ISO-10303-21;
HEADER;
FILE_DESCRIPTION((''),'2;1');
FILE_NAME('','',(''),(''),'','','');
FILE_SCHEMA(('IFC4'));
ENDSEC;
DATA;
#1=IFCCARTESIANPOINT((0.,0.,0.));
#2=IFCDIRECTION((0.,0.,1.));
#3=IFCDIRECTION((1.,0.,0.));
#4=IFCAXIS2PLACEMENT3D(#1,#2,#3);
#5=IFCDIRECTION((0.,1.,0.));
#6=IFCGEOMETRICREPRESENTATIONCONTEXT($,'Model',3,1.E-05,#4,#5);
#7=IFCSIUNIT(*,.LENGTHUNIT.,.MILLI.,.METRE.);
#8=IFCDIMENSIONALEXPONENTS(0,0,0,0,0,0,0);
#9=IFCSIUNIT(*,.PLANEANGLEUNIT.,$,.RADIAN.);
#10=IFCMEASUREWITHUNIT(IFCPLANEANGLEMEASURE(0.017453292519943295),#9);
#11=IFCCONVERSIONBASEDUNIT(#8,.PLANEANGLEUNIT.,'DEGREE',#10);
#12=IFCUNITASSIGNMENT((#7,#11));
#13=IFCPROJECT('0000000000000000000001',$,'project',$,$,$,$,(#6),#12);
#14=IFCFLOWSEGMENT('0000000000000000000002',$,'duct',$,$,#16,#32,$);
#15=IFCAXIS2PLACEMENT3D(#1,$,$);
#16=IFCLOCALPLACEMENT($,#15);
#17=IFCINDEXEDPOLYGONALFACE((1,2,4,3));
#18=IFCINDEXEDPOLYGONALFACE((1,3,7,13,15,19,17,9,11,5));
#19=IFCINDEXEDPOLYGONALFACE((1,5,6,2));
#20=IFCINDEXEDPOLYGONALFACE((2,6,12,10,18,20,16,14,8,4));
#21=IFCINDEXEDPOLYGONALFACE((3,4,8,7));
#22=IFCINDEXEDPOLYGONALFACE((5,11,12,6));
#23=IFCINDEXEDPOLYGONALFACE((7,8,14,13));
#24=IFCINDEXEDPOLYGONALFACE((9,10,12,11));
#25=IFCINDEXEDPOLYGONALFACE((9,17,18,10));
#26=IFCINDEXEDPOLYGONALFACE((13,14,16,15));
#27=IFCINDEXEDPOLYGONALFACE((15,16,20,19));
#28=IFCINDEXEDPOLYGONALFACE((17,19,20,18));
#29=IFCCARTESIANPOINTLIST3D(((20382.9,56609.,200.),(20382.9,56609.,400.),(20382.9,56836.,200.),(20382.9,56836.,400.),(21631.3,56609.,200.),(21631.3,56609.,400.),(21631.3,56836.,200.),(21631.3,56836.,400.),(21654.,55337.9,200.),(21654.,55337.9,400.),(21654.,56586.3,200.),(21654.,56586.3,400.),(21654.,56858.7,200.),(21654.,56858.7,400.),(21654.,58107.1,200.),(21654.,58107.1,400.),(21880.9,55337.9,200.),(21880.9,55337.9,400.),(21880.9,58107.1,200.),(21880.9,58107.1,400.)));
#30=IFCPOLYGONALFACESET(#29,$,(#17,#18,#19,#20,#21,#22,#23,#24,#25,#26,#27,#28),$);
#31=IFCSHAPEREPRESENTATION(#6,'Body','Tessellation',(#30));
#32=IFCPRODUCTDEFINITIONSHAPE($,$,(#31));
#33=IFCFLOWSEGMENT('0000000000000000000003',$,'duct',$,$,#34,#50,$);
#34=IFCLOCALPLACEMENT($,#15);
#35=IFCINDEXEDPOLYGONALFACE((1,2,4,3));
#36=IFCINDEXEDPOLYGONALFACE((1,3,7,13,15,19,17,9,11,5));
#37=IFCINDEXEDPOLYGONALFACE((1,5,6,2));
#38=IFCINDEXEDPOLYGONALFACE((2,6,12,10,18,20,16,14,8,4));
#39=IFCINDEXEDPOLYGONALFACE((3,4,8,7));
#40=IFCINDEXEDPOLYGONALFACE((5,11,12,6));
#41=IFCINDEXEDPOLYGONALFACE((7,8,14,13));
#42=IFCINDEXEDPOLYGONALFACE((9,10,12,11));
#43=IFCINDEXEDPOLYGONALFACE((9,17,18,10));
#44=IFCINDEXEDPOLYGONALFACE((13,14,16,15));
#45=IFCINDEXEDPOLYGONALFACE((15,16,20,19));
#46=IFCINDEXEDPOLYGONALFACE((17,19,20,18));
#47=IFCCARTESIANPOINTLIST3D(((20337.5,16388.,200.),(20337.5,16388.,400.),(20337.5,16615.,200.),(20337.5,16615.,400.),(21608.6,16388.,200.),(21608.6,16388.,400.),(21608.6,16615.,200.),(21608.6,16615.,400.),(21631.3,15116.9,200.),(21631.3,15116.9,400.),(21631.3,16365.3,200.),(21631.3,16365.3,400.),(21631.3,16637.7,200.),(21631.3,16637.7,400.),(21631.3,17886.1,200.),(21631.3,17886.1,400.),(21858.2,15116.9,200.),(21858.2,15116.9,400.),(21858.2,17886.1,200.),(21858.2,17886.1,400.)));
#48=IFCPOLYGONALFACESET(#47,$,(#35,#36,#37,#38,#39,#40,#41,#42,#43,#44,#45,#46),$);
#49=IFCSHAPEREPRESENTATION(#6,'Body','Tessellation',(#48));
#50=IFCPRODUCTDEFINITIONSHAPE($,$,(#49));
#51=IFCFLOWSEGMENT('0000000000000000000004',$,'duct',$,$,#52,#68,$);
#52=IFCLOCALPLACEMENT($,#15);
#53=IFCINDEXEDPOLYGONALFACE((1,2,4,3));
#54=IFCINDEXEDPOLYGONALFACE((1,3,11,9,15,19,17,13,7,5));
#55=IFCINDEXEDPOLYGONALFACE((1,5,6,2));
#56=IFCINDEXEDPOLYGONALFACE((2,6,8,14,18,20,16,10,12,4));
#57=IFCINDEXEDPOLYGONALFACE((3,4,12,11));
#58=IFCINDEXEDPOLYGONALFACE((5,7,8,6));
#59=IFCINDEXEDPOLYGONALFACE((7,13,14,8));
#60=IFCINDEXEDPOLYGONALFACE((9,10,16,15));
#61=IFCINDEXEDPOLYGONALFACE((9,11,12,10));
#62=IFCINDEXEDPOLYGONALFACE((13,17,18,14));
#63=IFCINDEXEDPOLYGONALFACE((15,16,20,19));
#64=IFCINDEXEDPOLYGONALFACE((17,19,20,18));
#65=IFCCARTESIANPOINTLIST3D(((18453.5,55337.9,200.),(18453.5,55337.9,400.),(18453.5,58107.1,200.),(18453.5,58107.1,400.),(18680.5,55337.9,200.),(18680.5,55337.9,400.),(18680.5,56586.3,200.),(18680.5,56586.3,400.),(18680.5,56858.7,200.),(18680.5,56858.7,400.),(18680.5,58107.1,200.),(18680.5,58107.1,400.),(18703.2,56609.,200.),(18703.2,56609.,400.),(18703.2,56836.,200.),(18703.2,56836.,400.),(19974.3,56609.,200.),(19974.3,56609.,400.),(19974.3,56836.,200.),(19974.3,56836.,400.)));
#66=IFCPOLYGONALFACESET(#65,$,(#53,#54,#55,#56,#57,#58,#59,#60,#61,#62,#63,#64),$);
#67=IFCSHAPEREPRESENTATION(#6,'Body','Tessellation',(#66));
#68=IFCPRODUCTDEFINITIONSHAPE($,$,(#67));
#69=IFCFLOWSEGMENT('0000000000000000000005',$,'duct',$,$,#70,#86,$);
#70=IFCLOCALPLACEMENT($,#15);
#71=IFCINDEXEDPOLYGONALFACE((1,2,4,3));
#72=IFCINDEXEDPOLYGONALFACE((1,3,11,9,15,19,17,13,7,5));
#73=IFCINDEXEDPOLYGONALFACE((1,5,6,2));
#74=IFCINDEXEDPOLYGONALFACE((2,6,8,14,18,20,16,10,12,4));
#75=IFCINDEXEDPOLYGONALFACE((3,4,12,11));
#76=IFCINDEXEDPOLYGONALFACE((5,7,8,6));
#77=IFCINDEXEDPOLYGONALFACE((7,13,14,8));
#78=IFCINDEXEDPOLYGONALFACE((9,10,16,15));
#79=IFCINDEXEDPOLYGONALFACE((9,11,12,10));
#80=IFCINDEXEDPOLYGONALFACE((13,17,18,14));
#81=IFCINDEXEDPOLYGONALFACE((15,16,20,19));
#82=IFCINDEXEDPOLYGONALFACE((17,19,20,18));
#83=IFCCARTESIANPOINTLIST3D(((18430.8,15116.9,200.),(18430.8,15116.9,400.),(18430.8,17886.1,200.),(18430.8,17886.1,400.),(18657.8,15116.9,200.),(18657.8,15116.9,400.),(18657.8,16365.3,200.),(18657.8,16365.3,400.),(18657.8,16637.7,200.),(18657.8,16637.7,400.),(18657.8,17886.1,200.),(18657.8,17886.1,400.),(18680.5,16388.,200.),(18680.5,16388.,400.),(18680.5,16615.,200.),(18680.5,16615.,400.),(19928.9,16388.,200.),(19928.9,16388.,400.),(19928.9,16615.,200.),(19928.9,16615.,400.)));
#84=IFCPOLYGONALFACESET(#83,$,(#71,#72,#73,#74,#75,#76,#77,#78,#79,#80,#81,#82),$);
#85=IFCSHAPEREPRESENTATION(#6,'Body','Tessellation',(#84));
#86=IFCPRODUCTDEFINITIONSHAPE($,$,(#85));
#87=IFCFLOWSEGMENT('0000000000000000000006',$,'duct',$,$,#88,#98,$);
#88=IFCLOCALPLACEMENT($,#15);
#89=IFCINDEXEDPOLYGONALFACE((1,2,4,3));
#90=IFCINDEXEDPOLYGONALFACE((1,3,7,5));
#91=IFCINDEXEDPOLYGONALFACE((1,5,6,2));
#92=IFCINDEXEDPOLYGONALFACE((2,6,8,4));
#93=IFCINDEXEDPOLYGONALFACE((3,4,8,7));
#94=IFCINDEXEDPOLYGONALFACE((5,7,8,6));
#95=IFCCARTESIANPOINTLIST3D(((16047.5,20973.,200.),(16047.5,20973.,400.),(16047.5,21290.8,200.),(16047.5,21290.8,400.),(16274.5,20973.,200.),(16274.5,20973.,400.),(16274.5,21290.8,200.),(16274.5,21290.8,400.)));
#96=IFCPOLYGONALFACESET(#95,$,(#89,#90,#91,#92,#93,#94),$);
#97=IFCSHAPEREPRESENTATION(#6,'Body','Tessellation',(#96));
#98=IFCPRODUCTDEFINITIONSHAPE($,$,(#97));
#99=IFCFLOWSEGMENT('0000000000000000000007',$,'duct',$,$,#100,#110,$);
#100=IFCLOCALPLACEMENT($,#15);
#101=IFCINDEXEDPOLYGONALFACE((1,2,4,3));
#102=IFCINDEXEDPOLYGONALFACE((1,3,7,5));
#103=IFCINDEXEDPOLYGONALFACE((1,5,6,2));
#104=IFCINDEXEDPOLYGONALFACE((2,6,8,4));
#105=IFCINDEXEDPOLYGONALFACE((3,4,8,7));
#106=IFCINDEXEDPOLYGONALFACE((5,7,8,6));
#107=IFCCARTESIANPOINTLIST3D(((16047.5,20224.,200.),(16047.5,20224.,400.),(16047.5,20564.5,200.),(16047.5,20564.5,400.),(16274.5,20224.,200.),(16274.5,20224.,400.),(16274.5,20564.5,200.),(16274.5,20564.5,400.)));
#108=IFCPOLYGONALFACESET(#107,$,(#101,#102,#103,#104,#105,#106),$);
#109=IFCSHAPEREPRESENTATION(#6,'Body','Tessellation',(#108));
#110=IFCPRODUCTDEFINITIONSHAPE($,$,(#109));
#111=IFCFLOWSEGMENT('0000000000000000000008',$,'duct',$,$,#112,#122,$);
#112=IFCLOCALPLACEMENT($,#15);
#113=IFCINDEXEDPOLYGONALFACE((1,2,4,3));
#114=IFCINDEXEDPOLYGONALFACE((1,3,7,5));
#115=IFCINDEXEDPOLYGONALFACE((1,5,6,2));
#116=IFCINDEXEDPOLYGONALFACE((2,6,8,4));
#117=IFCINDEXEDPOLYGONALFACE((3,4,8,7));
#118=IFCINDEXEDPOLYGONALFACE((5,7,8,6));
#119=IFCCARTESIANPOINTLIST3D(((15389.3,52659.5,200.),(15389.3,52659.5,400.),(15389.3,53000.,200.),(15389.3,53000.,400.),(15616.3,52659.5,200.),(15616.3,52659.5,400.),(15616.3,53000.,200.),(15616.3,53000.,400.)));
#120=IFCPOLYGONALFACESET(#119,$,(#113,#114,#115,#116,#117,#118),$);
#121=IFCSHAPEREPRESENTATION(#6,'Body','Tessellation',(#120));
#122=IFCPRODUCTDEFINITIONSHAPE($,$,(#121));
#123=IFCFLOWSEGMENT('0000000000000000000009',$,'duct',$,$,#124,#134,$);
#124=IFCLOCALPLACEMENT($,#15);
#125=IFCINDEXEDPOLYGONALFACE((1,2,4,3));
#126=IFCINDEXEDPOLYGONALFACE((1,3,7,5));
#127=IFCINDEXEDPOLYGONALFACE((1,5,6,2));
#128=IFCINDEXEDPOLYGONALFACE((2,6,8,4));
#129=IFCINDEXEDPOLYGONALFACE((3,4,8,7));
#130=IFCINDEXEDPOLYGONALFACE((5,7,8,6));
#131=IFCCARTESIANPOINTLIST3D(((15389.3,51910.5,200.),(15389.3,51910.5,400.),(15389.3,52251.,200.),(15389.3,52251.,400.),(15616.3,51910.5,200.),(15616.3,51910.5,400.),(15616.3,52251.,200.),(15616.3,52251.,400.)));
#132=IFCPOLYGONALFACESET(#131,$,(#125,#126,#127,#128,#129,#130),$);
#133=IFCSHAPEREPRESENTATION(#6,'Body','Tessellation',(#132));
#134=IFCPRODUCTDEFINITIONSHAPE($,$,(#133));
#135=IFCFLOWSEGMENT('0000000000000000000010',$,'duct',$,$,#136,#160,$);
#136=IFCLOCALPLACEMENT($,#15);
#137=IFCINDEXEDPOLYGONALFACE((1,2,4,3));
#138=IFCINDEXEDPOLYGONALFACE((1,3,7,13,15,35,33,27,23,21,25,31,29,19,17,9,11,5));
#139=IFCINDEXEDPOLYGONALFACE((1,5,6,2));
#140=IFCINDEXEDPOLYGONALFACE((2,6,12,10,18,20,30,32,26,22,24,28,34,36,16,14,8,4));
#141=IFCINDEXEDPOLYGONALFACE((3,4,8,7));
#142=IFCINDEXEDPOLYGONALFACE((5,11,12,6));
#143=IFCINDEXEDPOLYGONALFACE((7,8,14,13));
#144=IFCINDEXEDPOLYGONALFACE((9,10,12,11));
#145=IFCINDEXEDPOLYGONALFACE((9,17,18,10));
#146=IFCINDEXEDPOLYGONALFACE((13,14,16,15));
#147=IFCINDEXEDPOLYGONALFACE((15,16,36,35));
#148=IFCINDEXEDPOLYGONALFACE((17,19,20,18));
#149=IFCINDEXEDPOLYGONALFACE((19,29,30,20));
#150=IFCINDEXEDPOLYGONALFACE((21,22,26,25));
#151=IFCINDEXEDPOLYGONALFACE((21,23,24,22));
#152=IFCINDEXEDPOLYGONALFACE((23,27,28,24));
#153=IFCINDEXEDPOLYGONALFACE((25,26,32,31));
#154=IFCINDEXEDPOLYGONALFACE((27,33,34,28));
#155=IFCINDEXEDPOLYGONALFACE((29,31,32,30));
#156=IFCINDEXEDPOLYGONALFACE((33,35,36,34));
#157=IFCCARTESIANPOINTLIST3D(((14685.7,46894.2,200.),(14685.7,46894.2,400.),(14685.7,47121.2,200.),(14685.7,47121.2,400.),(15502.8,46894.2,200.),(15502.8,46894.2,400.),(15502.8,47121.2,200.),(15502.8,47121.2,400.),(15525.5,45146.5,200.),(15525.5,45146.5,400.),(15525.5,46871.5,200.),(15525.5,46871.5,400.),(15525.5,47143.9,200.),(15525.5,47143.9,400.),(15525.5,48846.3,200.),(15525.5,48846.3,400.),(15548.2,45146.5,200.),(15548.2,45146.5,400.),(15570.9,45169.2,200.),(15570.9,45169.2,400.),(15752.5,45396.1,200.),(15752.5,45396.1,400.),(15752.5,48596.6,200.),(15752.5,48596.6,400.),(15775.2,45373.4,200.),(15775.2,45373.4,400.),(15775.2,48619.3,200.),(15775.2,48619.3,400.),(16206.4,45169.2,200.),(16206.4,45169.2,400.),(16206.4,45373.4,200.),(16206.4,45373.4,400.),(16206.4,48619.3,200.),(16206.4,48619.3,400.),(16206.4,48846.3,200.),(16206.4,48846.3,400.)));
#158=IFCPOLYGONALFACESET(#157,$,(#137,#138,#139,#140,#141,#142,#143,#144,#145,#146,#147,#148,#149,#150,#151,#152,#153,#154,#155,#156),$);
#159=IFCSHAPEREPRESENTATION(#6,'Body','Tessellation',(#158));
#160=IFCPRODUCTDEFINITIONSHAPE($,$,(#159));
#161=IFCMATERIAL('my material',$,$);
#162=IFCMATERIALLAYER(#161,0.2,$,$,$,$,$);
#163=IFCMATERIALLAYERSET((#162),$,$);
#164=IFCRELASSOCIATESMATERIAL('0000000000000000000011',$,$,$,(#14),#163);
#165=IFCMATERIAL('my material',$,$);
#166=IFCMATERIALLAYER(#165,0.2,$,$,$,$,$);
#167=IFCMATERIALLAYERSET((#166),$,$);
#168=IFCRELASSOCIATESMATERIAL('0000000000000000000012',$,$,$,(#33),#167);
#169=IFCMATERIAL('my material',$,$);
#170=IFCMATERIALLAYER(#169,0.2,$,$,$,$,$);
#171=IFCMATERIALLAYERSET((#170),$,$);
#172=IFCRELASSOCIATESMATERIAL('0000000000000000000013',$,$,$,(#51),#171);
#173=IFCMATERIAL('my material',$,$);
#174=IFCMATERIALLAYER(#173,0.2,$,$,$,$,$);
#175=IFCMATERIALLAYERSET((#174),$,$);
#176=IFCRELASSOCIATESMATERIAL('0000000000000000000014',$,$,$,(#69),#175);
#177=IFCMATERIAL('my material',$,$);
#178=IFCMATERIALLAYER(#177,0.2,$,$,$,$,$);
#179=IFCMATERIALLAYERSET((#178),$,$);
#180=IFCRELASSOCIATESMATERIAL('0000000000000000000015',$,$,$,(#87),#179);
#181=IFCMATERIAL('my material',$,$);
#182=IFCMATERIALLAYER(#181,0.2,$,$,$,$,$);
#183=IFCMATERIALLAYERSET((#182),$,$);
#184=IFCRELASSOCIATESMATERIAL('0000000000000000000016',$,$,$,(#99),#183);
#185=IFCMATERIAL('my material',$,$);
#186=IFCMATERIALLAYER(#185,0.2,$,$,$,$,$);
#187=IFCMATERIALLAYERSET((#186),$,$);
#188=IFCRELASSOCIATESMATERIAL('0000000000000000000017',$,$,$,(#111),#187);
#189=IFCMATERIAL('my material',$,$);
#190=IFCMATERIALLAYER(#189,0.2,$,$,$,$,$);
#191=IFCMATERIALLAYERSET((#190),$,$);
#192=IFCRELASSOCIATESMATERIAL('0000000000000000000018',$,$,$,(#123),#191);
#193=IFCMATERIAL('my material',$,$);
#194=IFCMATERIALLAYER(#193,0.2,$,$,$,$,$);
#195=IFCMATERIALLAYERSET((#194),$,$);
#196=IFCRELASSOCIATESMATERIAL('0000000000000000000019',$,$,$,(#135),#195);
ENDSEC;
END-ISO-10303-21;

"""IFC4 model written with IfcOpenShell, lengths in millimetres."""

from ifc_helpers import new_model, entity, si_unit, converted_unit, direction, frame, origin_with_axes, place, context, project, polyline, outline, extrude, material, layer, layer_set, layer_usage, element, save


model = new_model("IFC4")

# Units and contexts
model_context = context("Model", 3, precision=1e-05, world=origin_with_axes(), true_north=direction((0.0, 1.0, 0.0)))
ifc_project = project(units=[si_unit("LENGTHUNIT", "METRE", prefix="MILLI"), converted_unit("PLANEANGLEUNIT", "DEGREE", entity("IfcPlaneAngleMeasure", 0.017453292519943295), si_unit("PLANEANGLEUNIT", "RADIAN"), dimensions=[0, 0, 0, 0, 0, 0, 0])], contexts=[model_context])

# Flow segments
ifc_material_1 = material(Name="my material")
ifc_layer_1 = layer(ifc_material_1, 0.2)
ifc_layer_set_1 = layer_set([ifc_layer_1])
ifc_layer_usage_1 = layer_usage(ifc_layer_set_1, "AXIS2", "POSITIVE", -0.1)
flow_segment_1_placement = place(None, origin_with_axes())
element("IfcFlowSegment", 1, at=flow_segment_1_placement, material=ifc_layer_usage_1, Name="duct", context=model_context, shape_type="SweptSolid", body=[
    extrude(outline(polyline([(20382.9, 56609.0), (21631.3, 56609.0), (21654.0, 56586.3), (21654.0, 55337.9), (21880.9, 55337.9), (21880.9, 58107.1), (21654.0, 58107.1), (21654.0, 56858.7), (21631.3, 56836.0), (20382.9, 56836.0), (20382.9, 56609.0)])), frame((0.0, 0.0, 200.0), z_axis=(0.0, 0.0, 1.0), x_axis=(1.0, 0.0, 0.0)), (0.0, 0.0, 1.0), 200.0),
])
ifc_material_2 = material(Name="my material")
ifc_layer_2 = layer(ifc_material_2, 0.2)
ifc_layer_set_2 = layer_set([ifc_layer_2])
ifc_layer_usage_2 = layer_usage(ifc_layer_set_2, "AXIS2", "POSITIVE", -0.1)
flow_segment_2_placement = place(None, origin_with_axes())
element("IfcFlowSegment", 2, at=flow_segment_2_placement, material=ifc_layer_usage_2, Name="duct", context=model_context, shape_type="SweptSolid", body=[
    extrude(outline(polyline([(20337.5, 16388.0), (21608.6, 16388.0), (21631.3, 16365.3), (21631.3, 15116.9), (21858.2, 15116.9), (21858.2, 17886.1), (21631.3, 17886.1), (21631.3, 16637.7), (21608.6, 16615.0), (20337.5, 16615.0), (20337.5, 16388.0)])), frame((0.0, 0.0, 200.0), z_axis=(0.0, 0.0, 1.0), x_axis=(1.0, 0.0, 0.0)), (0.0, 0.0, 1.0), 200.0),
])
ifc_material_3 = material(Name="my material")
ifc_layer_3 = layer(ifc_material_3, 0.2)
ifc_layer_set_3 = layer_set([ifc_layer_3])
ifc_layer_usage_3 = layer_usage(ifc_layer_set_3, "AXIS2", "POSITIVE", -0.1)
flow_segment_3_placement = place(None, origin_with_axes())
element("IfcFlowSegment", 3, at=flow_segment_3_placement, material=ifc_layer_usage_3, Name="duct", context=model_context, shape_type="SweptSolid", body=[
    extrude(outline(polyline([(18453.5, 55337.9), (18680.5, 55337.9), (18680.5, 56586.3), (18703.2, 56609.0), (19974.3, 56609.0), (19974.3, 56836.0), (18703.2, 56836.0), (18680.5, 56858.7), (18680.5, 58107.1), (18453.5, 58107.1), (18453.5, 55337.9)])), frame((0.0, 0.0, 200.0), z_axis=(0.0, 0.0, 1.0), x_axis=(1.0, 0.0, 0.0)), (0.0, 0.0, 1.0), 200.0),
])
ifc_material_4 = material(Name="my material")
ifc_layer_4 = layer(ifc_material_4, 0.2)
ifc_layer_set_4 = layer_set([ifc_layer_4])
ifc_layer_usage_4 = layer_usage(ifc_layer_set_4, "AXIS2", "POSITIVE", -0.1)
flow_segment_4_placement = place(None, origin_with_axes())
element("IfcFlowSegment", 4, at=flow_segment_4_placement, material=ifc_layer_usage_4, Name="duct", context=model_context, shape_type="SweptSolid", body=[
    extrude(outline(polyline([(18430.8, 15116.9), (18657.8, 15116.9), (18657.8, 16365.3), (18680.5, 16388.0), (19928.9, 16388.0), (19928.9, 16615.0), (18680.5, 16615.0), (18657.8, 16637.7), (18657.8, 17886.1), (18430.8, 17886.1), (18430.8, 15116.9)])), frame((0.0, 0.0, 200.0), z_axis=(0.0, 0.0, 1.0), x_axis=(1.0, 0.0, 0.0)), (0.0, 0.0, 1.0), 200.0),
])
ifc_material_5 = material(Name="my material")
ifc_layer_5 = layer(ifc_material_5, 0.2)
ifc_layer_set_5 = layer_set([ifc_layer_5])
ifc_layer_usage_5 = layer_usage(ifc_layer_set_5, "AXIS2", "POSITIVE", -0.1)
flow_segment_5_placement = place(None, origin_with_axes())
element("IfcFlowSegment", 5, at=flow_segment_5_placement, material=ifc_layer_usage_5, Name="duct", context=model_context, shape_type="SweptSolid", body=[
    extrude(outline(polyline([(16047.5, 20973.0), (16274.5, 20973.0), (16274.5, 21290.8), (16047.5, 21290.8), (16047.5, 20973.0)])), frame((0.0, 0.0, 200.0), z_axis=(0.0, 0.0, 1.0), x_axis=(1.0, 0.0, 0.0)), (0.0, 0.0, 1.0), 200.0),
])
ifc_material_6 = material(Name="my material")
ifc_layer_6 = layer(ifc_material_6, 0.2)
ifc_layer_set_6 = layer_set([ifc_layer_6])
ifc_layer_usage_6 = layer_usage(ifc_layer_set_6, "AXIS2", "POSITIVE", -0.1)
flow_segment_6_placement = place(None, origin_with_axes())
element("IfcFlowSegment", 6, at=flow_segment_6_placement, material=ifc_layer_usage_6, Name="duct", context=model_context, shape_type="SweptSolid", body=[
    extrude(outline(polyline([(16047.5, 20224.0), (16274.5, 20224.0), (16274.5, 20564.5), (16047.5, 20564.5), (16047.5, 20224.0)])), frame((0.0, 0.0, 200.0), z_axis=(0.0, 0.0, 1.0), x_axis=(1.0, 0.0, 0.0)), (0.0, 0.0, 1.0), 200.0),
])
ifc_material_7 = material(Name="my material")
ifc_layer_7 = layer(ifc_material_7, 0.2)
ifc_layer_set_7 = layer_set([ifc_layer_7])
ifc_layer_usage_7 = layer_usage(ifc_layer_set_7, "AXIS2", "POSITIVE", -0.1)
flow_segment_7_placement = place(None, origin_with_axes())
element("IfcFlowSegment", 7, at=flow_segment_7_placement, material=ifc_layer_usage_7, Name="duct", context=model_context, shape_type="SweptSolid", body=[
    extrude(outline(polyline([(15389.3, 52659.5), (15616.3, 52659.5), (15616.3, 53000.0), (15389.3, 53000.0), (15389.3, 52659.5)])), frame((0.0, 0.0, 200.0), z_axis=(0.0, 0.0, 1.0), x_axis=(1.0, 0.0, 0.0)), (0.0, 0.0, 1.0), 200.0),
])
ifc_material_8 = material(Name="my material")
ifc_layer_8 = layer(ifc_material_8, 0.2)
ifc_layer_set_8 = layer_set([ifc_layer_8])
ifc_layer_usage_8 = layer_usage(ifc_layer_set_8, "AXIS2", "POSITIVE", -0.1)
flow_segment_8_placement = place(None, origin_with_axes())
element("IfcFlowSegment", 8, at=flow_segment_8_placement, material=ifc_layer_usage_8, Name="duct", context=model_context, shape_type="SweptSolid", body=[
    extrude(outline(polyline([(15389.3, 51910.5), (15616.3, 51910.5), (15616.3, 52251.0), (15389.3, 52251.0), (15389.3, 51910.5)])), frame((0.0, 0.0, 200.0), z_axis=(0.0, 0.0, 1.0), x_axis=(1.0, 0.0, 0.0)), (0.0, 0.0, 1.0), 200.0),
])
ifc_material_9 = material(Name="my material")
ifc_layer_9 = layer(ifc_material_9, 0.2)
ifc_layer_set_9 = layer_set([ifc_layer_9])
ifc_layer_usage_9 = layer_usage(ifc_layer_set_9, "AXIS2", "POSITIVE", -0.1)
flow_segment_9_placement = place(None, origin_with_axes())
element("IfcFlowSegment", 9, at=flow_segment_9_placement, material=ifc_layer_usage_9, Name="duct", context=model_context, shape_type="SweptSolid", body=[
    extrude(outline(polyline([(14685.7, 46894.2), (15502.8, 46894.2), (15525.5, 46871.5), (15525.5, 45146.5), (15548.2, 45146.5), (15570.9, 45169.2), (16206.4, 45169.2), (16206.4, 45373.4), (15775.2, 45373.4), (15752.5, 45396.1), (15752.5, 48596.6), (15775.2, 48619.3), (16206.4, 48619.3), (16206.4, 48846.3), (15525.5, 48846.3), (15525.5, 47143.9), (15502.8, 47121.2), (14685.7, 47121.2), (14685.7, 46894.2)])), frame((0.0, 0.0, 200.0), z_axis=(0.0, 0.0, 1.0), x_axis=(1.0, 0.0, 0.0)), (0.0, 0.0, 1.0), 200.0),
])

save(model, "model.ifc")
